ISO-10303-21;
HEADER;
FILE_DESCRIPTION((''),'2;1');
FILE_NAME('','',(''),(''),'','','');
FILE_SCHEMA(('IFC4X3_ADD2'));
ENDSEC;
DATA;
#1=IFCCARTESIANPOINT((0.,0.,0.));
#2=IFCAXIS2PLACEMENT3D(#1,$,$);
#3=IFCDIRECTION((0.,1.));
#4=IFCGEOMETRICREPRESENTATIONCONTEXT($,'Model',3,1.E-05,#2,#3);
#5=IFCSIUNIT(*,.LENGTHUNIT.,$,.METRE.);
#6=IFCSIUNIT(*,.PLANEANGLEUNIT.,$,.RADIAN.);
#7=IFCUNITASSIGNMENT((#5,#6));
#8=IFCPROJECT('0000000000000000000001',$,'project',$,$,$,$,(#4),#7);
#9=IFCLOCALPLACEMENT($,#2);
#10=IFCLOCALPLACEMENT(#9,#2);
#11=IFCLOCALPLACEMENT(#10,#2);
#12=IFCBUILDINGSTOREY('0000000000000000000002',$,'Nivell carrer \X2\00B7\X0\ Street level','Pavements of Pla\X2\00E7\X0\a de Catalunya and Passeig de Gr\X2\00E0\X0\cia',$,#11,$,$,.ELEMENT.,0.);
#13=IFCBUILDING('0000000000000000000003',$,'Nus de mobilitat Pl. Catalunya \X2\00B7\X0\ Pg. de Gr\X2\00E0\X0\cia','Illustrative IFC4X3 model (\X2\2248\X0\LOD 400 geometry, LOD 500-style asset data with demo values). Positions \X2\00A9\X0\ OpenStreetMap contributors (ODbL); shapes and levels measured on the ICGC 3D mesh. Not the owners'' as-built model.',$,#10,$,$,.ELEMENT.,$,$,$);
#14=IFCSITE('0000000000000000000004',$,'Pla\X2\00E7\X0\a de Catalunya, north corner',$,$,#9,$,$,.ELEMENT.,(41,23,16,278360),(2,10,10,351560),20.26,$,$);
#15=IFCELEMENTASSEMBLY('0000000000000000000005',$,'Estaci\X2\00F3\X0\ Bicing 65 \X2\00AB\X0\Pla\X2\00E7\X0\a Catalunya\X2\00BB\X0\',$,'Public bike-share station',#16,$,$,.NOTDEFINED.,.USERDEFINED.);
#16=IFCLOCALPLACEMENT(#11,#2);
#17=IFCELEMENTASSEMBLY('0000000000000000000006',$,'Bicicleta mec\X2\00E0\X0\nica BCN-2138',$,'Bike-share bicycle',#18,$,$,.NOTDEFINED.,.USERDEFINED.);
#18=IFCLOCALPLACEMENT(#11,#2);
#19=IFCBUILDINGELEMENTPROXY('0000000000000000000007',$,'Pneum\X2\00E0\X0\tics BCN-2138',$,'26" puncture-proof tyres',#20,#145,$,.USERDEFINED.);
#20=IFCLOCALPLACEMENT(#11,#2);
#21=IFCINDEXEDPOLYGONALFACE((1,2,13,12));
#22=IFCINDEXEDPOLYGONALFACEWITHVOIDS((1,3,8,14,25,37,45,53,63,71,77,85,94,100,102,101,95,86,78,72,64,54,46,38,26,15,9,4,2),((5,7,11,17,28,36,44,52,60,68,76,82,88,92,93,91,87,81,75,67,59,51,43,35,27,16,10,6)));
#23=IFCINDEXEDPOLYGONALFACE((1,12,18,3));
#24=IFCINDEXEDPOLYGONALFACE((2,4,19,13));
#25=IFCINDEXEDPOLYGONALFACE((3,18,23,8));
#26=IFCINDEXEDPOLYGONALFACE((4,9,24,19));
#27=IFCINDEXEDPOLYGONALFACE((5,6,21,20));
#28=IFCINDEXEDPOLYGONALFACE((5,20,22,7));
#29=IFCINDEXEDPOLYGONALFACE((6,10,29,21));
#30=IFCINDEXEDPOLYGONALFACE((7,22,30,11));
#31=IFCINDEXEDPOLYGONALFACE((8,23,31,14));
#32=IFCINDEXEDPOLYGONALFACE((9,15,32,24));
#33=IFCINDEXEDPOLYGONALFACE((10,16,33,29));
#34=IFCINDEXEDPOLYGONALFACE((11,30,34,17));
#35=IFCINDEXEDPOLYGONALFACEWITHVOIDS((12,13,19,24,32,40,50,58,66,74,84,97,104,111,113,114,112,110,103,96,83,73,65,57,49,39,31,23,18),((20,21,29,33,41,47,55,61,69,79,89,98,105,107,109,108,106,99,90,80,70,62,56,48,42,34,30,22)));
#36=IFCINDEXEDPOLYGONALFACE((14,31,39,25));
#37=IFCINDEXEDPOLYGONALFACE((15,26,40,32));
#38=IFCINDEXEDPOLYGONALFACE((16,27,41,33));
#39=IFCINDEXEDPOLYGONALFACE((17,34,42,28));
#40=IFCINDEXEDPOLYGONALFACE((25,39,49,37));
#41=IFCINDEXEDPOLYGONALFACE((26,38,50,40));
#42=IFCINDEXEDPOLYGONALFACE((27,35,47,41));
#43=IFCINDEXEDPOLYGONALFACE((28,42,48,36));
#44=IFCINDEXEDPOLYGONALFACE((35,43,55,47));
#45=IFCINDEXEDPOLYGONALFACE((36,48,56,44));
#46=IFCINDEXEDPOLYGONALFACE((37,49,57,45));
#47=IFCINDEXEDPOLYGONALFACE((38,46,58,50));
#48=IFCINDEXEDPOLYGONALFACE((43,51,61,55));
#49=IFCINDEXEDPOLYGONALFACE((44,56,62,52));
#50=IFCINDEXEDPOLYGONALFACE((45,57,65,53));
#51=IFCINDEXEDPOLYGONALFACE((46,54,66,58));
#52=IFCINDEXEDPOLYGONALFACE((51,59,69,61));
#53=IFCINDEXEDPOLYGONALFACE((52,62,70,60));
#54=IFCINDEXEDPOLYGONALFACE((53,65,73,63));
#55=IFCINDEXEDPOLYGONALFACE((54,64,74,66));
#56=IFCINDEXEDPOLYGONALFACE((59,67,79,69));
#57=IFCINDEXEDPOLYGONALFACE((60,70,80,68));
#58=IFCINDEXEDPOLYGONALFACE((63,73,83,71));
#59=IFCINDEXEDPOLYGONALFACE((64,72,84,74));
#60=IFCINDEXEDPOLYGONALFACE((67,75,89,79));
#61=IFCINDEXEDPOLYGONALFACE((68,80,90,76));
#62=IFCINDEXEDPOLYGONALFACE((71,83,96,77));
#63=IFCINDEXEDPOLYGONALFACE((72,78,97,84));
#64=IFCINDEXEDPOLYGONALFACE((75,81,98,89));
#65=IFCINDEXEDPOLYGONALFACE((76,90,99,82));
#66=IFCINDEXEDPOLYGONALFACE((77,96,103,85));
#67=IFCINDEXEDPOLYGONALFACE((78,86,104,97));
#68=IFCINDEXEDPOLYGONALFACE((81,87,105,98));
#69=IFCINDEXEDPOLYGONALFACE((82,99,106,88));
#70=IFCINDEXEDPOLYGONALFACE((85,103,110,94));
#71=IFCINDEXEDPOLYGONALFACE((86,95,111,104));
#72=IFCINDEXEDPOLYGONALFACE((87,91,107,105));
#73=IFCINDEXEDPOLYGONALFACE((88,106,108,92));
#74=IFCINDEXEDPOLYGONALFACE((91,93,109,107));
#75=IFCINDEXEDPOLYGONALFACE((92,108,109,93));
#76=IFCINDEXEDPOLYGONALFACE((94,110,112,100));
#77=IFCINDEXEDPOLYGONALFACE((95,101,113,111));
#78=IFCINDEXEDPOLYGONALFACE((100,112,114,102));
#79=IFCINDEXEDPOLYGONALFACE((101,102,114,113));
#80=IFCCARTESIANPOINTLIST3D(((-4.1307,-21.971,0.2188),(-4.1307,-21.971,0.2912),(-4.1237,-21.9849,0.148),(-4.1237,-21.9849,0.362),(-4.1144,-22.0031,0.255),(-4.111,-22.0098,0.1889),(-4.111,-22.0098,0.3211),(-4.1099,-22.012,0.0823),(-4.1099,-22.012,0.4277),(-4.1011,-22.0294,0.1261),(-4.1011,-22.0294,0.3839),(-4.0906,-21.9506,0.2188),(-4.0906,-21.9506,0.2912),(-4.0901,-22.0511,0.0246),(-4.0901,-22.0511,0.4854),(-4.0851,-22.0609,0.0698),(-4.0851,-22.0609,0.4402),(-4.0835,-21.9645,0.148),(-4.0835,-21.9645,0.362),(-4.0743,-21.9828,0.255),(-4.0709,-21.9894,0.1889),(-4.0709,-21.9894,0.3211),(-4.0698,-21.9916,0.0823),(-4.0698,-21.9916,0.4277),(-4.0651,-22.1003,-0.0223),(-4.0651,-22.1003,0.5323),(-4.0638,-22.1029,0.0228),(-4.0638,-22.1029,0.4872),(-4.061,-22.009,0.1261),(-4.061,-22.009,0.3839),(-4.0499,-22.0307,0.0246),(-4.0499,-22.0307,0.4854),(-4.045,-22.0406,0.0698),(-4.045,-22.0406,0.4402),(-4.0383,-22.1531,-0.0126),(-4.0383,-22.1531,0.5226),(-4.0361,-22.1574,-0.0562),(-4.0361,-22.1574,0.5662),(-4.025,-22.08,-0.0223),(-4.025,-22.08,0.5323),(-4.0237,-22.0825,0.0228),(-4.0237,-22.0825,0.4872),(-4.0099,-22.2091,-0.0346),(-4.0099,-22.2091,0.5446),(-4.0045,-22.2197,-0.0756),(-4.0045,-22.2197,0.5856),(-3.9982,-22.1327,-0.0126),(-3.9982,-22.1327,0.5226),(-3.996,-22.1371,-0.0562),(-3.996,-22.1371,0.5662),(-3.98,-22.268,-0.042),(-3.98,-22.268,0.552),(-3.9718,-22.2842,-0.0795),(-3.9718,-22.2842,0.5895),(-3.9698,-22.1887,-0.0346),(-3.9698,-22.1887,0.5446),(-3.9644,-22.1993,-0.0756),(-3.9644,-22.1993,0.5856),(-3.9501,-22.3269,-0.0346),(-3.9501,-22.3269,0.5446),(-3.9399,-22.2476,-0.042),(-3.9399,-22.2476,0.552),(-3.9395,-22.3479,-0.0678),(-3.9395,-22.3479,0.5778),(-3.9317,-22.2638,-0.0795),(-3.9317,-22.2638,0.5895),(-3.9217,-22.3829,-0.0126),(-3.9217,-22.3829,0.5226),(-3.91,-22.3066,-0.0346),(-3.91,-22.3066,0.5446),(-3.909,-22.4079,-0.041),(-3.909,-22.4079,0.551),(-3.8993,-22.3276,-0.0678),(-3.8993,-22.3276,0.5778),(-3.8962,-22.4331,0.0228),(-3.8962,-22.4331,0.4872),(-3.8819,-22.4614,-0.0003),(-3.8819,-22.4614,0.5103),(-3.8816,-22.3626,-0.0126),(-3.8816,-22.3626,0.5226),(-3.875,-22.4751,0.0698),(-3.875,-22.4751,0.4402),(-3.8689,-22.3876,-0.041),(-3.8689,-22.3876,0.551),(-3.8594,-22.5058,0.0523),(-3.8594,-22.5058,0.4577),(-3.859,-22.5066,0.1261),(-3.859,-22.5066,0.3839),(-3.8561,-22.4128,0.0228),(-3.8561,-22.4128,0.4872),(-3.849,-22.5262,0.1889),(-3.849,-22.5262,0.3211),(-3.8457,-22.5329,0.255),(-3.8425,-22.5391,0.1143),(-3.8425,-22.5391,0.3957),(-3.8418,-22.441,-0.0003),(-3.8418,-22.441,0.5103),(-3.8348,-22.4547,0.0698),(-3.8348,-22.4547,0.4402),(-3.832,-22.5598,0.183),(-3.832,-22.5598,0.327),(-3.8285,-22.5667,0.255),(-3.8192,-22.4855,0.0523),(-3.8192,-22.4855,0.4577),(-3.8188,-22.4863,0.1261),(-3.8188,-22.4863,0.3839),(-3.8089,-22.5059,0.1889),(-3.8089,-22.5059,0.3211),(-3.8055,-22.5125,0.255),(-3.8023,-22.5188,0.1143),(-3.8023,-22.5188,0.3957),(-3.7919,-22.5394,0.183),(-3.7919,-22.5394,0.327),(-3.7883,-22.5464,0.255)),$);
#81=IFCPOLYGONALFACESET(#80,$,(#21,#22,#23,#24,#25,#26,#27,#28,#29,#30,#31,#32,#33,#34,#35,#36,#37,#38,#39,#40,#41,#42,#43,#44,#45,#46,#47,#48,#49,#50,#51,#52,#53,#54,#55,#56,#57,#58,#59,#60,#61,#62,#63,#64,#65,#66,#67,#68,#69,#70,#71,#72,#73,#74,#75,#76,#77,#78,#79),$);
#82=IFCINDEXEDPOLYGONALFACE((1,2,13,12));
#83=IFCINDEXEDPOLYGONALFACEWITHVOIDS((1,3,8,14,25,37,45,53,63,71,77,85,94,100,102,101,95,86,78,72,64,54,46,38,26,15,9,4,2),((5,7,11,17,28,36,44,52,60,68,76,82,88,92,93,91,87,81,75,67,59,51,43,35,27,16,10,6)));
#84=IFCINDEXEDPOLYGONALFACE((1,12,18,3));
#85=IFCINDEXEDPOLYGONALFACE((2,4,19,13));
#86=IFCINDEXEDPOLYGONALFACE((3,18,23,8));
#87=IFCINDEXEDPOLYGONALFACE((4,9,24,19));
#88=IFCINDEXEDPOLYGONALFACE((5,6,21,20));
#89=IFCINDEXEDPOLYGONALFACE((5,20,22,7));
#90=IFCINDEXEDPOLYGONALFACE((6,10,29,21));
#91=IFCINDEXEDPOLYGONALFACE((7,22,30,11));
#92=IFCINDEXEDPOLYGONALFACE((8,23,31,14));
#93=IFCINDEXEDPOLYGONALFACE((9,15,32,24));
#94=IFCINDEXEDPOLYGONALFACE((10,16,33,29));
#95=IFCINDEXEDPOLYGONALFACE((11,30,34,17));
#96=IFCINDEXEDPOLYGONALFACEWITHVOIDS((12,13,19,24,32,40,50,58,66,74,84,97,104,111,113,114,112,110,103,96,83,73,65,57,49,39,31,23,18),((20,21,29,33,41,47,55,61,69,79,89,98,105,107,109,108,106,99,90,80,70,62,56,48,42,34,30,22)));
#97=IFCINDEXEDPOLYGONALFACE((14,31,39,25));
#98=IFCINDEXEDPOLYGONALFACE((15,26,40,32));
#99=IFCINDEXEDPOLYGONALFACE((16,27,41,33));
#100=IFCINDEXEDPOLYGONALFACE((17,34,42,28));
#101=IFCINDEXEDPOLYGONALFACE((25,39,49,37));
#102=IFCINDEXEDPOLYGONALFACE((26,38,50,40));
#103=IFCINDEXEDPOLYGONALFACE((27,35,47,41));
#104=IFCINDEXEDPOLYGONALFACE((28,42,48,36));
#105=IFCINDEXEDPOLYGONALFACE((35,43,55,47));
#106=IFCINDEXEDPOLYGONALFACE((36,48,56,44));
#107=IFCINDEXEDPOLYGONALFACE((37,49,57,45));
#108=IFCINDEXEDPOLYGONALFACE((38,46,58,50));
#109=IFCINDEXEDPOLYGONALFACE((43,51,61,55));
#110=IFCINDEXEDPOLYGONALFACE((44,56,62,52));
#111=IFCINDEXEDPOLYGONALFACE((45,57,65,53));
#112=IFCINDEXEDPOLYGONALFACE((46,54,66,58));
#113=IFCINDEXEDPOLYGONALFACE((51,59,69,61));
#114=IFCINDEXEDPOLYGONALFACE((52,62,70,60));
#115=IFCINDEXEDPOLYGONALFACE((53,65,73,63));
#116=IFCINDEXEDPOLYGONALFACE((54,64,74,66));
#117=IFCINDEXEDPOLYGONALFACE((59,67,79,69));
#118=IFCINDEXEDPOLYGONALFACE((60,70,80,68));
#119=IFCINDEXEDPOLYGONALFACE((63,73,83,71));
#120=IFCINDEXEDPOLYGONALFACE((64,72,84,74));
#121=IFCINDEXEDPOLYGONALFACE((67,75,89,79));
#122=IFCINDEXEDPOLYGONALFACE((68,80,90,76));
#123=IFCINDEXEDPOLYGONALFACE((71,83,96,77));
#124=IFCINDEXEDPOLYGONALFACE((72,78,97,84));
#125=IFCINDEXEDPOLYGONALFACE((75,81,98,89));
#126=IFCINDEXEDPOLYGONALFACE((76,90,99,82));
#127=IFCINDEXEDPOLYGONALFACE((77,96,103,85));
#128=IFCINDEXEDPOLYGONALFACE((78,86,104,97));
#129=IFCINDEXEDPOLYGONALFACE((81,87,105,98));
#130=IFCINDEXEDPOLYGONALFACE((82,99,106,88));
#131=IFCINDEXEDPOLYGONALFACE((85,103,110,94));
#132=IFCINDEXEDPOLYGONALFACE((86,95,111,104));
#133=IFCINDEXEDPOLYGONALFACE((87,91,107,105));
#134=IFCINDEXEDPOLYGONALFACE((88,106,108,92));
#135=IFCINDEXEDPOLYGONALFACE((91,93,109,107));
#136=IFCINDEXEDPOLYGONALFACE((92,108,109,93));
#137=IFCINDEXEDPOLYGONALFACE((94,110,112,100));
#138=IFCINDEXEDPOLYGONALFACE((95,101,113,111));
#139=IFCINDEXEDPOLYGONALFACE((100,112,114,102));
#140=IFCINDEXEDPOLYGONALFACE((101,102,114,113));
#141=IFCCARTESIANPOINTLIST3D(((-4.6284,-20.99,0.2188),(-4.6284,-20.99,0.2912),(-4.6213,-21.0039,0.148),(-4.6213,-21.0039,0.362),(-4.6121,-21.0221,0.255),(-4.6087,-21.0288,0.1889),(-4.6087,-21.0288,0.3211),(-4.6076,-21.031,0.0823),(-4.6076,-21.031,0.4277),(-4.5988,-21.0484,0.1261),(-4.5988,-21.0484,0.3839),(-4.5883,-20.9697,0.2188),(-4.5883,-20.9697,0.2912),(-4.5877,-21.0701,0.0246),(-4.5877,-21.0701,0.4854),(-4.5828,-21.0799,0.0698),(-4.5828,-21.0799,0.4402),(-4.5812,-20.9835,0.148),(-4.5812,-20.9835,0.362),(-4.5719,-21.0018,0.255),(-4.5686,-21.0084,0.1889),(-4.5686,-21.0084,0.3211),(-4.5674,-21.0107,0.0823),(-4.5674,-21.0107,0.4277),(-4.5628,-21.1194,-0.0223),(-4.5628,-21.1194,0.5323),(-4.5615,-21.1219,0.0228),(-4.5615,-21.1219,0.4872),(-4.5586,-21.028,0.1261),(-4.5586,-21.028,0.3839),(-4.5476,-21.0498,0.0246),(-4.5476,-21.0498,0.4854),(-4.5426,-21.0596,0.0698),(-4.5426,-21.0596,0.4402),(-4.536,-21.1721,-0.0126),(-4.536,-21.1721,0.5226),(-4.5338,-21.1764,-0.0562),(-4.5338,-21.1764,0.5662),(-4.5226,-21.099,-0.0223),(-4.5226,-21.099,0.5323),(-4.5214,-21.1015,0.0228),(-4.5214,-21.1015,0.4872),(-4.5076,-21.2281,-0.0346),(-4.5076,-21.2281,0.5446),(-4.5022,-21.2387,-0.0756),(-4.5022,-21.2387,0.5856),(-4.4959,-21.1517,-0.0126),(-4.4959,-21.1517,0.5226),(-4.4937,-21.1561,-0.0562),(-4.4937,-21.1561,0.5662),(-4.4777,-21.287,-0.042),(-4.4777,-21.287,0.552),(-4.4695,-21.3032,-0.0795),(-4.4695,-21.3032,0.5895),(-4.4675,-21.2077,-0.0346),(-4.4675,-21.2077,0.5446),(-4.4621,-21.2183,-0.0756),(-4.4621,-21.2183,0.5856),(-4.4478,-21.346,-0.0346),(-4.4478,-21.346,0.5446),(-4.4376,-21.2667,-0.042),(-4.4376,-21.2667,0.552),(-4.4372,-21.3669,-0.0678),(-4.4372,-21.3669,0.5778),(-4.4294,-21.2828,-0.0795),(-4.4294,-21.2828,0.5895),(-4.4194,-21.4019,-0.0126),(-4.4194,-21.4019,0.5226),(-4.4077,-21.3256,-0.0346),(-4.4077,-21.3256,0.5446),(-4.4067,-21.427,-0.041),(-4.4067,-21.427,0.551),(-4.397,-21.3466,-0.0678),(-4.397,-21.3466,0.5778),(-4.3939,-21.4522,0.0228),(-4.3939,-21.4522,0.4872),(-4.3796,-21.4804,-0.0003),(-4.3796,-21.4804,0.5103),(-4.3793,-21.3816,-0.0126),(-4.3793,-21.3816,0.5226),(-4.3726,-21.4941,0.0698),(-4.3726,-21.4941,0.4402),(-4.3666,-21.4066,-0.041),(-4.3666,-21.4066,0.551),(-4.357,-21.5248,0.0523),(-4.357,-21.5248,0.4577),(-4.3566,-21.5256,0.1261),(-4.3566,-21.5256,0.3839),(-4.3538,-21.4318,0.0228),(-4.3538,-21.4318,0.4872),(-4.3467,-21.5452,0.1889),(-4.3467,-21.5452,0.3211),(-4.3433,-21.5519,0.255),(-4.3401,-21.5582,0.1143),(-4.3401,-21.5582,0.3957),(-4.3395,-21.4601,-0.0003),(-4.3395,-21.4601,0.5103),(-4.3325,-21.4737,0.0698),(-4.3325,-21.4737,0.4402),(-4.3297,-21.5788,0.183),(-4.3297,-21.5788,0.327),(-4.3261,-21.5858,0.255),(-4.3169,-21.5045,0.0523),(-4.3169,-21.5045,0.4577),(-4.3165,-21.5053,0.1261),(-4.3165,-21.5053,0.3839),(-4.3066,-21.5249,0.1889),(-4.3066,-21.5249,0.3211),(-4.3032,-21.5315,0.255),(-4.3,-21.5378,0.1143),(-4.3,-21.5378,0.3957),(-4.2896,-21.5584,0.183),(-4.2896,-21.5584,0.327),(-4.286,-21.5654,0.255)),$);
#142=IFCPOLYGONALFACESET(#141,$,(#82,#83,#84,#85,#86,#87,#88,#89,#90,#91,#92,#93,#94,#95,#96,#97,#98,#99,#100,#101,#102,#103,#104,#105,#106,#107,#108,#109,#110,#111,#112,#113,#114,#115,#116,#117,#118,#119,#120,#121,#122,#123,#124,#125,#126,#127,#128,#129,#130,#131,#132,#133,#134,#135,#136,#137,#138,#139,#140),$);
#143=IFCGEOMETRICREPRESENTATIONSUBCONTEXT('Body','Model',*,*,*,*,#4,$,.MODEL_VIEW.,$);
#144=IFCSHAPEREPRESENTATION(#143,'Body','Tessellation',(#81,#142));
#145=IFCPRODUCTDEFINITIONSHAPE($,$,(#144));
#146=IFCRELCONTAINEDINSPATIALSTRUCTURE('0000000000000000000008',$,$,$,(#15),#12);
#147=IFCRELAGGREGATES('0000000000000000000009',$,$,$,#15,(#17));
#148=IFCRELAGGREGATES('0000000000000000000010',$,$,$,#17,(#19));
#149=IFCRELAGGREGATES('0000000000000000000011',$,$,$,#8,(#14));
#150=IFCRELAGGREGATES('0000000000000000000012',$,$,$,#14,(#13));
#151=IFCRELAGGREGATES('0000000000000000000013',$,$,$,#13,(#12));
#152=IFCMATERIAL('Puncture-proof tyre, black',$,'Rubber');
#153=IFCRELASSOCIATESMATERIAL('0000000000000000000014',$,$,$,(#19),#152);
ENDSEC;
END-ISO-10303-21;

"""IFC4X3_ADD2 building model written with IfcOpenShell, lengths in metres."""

from ifc_helpers import new_model, si_unit, direction, frame, origin, origin_2d_with_axis, place, context, subcontext, project, spatial, hollow_circle, extrude, material, element, aggregate, save


model = new_model("IFC4X3_ADD2")

# Units and contexts
model_context = context("Model", 3, precision=1e-05, world=origin(), true_north=direction((0.0, 1.0)))
body_context = subcontext(model_context, "Body", "Model", "MODEL_VIEW")
ifc_project = project(units=[si_unit("LENGTHUNIT", "METRE"), si_unit("PLANEANGLEUNIT", "RADIAN")], contexts=[model_context])

# Site, building, storey
site_placement = place(None, origin())
site = spatial("IfcSite", under=ifc_project, at=site_placement, Name="Plaça de Catalunya, north corner", CompositionType="ELEMENT", RefLatitude=(41, 23, 16, 278360), RefLongitude=(2, 10, 10, 351560), RefElevation=20.26)
building_placement = place(site_placement, origin())
building = spatial("IfcBuilding", under=site, at=building_placement, Name="Nus de mobilitat Pl. Catalunya · Pg. de Gràcia", Description="Illustrative IFC4X3 model (≈LOD 400 geometry, LOD 500-style asset data with demo values). Positions © OpenStreetMap contributors (ODbL); shapes and levels measured on the ICGC 3D mesh. Not the owners' as-built model.", CompositionType="ELEMENT")
storey_placement = place(building_placement, origin())
storey = spatial("IfcBuildingStorey", under=building, at=storey_placement, Name="Nivell carrer · Street level", Description="Pavements of Plaça de Catalunya and Passeig de Gràcia", CompositionType="ELEMENT", Elevation=0.0)

# Element assemblies, building element proxy
assembly_1_placement = place(building_placement, origin())
assembly_1 = element("IfcElementAssembly", 1, at=assembly_1_placement, inside=storey, Name="Estació Bicing 65 «Plaça Catalunya»", ObjectType="Public bike-share station", AssemblyPlace="NOTDEFINED", PredefinedType="USERDEFINED")
ifc_material_1 = material(Name="Puncture-proof tyre, black", Category="Rubber")
assembly_2_placement = place(building_placement, origin())
assembly_2 = element("IfcElementAssembly", 2, at=assembly_2_placement, Name="Bicicleta mecànica BCN-2138", ObjectType="Bike-share bicycle", AssemblyPlace="NOTDEFINED", PredefinedType="USERDEFINED")
aggregate(assembly_1, [assembly_2])
proxy_1_placement = place(building_placement, origin())
proxy_1 = element("IfcBuildingElementProxy", 3, at=proxy_1_placement, material=ifc_material_1, Name="Pneumàtics BCN-2138", ObjectType="26\" puncture-proof tyres", PredefinedType="USERDEFINED", context=body_context, shape_type="SweptSolid", body=[
    extrude(hollow_circle(Radius=0.335, WallThickness=0.038, at=origin_2d_with_axis()), frame((-3.98, -22.268, 0.255), z_axis=(0.891798, 0.452435, 0.0), x_axis=(0.452435, -0.891798, 0.0)), (0.0, 0.0, 1.0), 0.045),
    extrude(hollow_circle(Radius=0.335, WallThickness=0.038, at=origin_2d_with_axis()), frame((-4.4777, -21.287, 0.255), z_axis=(0.891798, 0.452435, 0.0), x_axis=(0.452435, -0.891798, 0.0)), (0.0, 0.0, 1.0), 0.045),
])
aggregate(assembly_2, [proxy_1])

save(model, "model.ifc")
